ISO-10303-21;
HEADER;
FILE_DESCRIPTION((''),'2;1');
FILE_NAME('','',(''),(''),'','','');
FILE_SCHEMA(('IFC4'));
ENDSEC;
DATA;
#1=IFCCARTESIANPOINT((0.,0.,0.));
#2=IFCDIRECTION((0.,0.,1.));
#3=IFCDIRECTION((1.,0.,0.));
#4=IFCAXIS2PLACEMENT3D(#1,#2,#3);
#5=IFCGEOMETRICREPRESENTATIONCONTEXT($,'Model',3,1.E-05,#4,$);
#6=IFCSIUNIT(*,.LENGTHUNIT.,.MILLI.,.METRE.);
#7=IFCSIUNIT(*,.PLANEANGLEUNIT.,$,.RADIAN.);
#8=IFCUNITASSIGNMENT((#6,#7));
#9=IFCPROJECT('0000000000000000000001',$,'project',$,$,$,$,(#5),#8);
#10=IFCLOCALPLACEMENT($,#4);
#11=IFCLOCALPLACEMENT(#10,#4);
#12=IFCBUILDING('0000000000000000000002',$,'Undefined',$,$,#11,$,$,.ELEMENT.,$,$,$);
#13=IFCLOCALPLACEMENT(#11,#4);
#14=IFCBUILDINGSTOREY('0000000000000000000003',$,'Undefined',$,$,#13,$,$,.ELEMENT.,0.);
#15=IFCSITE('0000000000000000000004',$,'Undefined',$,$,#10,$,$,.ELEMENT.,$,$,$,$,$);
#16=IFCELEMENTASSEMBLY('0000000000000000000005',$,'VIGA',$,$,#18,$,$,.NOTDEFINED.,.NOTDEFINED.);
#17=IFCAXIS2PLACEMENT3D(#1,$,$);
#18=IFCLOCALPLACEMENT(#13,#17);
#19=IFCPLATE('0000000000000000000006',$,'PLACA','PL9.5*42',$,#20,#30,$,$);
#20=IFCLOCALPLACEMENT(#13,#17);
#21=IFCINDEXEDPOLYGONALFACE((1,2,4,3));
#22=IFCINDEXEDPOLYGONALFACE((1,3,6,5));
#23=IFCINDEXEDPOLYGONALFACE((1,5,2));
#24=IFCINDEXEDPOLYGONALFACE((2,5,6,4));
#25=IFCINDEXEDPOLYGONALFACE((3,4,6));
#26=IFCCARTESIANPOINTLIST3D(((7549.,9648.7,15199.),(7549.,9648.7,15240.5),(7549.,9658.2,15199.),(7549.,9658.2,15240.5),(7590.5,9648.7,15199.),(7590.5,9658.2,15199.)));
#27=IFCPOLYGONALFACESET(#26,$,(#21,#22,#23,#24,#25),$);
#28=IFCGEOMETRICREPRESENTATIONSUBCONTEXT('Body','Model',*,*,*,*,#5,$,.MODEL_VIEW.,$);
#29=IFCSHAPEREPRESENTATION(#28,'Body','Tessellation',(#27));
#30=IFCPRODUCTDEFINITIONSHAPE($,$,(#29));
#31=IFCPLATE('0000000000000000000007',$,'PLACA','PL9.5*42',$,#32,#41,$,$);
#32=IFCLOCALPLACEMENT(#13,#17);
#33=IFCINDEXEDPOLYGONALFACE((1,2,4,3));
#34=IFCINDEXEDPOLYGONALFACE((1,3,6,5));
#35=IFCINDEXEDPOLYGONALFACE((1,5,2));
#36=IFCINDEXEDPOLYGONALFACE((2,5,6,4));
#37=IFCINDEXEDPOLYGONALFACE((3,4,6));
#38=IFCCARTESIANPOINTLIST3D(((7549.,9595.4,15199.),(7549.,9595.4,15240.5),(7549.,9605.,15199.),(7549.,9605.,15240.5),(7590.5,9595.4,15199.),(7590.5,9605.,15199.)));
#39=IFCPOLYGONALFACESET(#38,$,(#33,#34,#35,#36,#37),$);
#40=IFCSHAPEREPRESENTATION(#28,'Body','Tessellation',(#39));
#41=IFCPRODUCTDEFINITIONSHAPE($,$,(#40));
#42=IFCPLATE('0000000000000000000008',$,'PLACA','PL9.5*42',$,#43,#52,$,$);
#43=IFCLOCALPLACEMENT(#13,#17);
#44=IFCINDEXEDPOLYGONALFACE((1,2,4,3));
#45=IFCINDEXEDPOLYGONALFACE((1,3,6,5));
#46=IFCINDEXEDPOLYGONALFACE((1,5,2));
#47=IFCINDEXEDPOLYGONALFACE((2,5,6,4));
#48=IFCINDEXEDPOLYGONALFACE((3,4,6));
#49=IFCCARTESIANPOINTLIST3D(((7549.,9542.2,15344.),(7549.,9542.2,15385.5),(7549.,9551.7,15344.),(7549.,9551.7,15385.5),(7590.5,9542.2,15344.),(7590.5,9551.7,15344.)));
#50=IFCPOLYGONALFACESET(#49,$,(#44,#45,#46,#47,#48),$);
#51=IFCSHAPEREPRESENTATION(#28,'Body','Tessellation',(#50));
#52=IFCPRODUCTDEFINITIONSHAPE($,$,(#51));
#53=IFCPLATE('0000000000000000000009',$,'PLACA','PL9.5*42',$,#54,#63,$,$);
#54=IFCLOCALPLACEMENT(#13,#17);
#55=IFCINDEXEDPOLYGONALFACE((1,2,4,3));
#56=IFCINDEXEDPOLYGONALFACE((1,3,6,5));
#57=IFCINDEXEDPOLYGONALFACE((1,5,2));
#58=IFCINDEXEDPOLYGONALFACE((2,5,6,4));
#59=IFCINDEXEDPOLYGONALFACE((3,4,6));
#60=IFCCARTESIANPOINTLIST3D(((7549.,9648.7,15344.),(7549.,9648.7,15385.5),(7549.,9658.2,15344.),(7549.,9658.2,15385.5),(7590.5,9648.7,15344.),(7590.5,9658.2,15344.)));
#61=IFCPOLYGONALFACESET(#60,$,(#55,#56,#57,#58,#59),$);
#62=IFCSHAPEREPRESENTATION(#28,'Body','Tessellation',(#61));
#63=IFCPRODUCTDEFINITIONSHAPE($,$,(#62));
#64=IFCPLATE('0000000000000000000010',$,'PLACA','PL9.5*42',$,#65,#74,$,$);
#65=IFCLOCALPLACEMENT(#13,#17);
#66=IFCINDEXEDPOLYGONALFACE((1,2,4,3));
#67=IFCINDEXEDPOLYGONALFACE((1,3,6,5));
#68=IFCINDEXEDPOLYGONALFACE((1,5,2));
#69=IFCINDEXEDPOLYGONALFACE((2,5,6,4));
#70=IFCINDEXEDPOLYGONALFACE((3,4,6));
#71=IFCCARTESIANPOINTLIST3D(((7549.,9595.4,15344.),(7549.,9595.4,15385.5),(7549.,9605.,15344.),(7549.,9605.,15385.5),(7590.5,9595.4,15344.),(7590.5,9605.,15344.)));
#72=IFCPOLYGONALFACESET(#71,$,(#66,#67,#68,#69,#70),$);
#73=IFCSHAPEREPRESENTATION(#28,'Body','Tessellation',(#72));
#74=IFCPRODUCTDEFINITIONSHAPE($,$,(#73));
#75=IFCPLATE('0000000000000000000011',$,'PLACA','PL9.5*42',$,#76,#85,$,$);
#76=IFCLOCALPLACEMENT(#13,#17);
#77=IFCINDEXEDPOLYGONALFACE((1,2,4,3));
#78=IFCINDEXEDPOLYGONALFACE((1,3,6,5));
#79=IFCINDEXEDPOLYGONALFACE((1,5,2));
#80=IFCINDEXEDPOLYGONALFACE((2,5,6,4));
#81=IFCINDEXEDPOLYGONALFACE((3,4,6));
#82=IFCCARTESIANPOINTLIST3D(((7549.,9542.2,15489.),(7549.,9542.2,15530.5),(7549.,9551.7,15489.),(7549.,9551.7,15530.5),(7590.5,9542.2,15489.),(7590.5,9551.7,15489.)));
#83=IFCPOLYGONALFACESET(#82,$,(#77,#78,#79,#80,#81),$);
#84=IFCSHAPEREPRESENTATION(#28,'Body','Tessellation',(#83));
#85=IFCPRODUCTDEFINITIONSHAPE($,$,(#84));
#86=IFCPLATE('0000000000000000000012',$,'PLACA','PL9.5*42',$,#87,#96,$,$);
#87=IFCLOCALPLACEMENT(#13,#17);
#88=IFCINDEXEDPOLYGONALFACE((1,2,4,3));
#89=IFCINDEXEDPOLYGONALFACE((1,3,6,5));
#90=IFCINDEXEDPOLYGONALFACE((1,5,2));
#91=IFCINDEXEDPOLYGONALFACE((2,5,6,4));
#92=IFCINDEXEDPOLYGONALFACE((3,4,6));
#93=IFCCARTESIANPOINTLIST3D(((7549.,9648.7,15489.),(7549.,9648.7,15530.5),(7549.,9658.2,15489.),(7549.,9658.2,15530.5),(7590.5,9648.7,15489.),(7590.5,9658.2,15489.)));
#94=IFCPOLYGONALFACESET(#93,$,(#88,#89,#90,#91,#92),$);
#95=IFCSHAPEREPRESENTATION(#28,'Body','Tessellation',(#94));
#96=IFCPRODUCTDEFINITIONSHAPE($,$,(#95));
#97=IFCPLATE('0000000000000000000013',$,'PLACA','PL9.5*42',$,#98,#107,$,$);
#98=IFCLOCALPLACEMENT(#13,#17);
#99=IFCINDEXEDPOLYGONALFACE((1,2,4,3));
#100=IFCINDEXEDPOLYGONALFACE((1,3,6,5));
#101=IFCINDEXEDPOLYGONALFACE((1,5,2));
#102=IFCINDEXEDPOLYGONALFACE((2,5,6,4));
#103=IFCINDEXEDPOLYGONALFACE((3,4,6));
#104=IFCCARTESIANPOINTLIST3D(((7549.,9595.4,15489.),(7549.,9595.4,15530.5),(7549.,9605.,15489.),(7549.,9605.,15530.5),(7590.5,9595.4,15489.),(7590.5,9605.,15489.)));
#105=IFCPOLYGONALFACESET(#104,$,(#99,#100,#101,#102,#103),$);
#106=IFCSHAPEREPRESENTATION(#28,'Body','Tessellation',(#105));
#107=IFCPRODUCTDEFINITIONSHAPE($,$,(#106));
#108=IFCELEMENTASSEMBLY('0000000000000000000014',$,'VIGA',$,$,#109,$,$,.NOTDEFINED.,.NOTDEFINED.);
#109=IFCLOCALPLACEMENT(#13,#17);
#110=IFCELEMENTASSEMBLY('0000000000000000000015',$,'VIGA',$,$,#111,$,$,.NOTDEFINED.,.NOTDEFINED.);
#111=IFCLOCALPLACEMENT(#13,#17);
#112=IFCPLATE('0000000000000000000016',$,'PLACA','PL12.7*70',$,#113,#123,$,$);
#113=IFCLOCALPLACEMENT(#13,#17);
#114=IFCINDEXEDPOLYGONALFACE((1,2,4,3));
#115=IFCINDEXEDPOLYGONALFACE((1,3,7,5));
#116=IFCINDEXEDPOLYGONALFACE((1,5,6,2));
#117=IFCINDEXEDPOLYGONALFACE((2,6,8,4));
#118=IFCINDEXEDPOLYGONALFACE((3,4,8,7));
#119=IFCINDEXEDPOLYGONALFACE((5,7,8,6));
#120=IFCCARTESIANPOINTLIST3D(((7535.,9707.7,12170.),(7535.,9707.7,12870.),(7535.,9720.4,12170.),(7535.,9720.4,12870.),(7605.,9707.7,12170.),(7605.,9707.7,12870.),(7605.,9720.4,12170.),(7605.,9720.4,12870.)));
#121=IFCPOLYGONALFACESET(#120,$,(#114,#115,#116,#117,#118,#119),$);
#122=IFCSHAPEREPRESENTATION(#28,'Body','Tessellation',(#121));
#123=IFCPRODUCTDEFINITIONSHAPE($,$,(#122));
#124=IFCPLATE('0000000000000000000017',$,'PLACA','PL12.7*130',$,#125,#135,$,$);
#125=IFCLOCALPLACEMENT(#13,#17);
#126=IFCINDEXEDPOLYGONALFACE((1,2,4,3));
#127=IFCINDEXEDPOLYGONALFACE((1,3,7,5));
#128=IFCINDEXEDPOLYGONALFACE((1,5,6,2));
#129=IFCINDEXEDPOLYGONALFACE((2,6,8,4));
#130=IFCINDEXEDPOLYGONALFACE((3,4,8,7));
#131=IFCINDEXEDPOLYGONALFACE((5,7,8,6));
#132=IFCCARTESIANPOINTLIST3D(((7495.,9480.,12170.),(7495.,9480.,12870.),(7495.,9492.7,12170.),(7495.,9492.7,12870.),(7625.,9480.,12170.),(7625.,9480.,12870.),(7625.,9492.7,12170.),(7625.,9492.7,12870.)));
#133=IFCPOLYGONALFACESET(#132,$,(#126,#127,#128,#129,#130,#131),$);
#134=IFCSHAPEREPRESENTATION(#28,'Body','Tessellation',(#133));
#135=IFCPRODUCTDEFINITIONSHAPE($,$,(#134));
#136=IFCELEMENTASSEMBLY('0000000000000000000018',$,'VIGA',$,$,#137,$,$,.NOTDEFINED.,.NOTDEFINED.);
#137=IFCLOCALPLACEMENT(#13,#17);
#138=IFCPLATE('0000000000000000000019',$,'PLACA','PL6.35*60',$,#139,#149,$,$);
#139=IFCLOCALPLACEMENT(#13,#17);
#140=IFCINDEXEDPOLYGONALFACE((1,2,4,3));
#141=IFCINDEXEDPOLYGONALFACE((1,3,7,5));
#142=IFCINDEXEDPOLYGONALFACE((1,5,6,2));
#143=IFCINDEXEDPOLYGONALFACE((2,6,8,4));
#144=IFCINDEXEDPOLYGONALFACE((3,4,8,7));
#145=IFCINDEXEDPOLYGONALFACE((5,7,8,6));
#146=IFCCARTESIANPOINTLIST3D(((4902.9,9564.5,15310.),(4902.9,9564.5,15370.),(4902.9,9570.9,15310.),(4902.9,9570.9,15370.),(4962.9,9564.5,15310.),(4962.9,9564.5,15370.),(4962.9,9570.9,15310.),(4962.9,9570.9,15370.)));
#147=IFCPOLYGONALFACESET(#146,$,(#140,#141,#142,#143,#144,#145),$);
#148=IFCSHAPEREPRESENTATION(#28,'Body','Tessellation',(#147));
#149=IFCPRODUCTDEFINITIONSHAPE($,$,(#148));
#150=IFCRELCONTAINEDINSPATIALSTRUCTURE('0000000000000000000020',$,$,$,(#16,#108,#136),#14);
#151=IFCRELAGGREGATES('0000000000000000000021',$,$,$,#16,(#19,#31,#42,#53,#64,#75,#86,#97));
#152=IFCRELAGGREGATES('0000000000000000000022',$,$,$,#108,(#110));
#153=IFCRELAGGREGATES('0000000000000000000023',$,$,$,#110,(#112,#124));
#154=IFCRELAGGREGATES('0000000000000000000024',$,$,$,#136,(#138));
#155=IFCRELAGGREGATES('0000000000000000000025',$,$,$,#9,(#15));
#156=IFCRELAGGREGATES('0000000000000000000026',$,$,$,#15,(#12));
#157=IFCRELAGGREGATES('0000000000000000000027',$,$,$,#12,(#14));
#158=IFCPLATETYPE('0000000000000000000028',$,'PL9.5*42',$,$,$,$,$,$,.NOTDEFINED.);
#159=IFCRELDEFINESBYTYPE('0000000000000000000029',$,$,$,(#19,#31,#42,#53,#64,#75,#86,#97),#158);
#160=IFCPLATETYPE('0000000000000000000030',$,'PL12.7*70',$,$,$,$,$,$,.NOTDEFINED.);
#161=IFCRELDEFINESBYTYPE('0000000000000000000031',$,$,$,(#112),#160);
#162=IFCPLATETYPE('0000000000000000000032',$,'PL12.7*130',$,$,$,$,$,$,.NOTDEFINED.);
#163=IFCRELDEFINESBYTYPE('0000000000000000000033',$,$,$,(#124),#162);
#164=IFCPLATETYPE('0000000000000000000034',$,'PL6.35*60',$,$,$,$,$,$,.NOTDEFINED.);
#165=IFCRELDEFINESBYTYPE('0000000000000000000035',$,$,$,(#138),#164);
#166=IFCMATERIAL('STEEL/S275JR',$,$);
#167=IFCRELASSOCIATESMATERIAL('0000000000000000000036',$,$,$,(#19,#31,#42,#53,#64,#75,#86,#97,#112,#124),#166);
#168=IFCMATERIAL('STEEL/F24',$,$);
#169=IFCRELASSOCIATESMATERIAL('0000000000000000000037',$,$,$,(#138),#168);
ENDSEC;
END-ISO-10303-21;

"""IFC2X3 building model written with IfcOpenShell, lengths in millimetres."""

from ifc_helpers import new_model, si_unit, frame, origin_with_axes, place, context, subcontext, project, spatial, polyline, outline, extrude, material, type_object, element, aggregate, save


model = new_model("IFC2X3")

# Units and contexts
model_context = context("Model", 3, precision=1e-05, world=origin_with_axes())
body_context = subcontext(model_context, "Body", "Model", "MODEL_VIEW")
ifc_project = project(units=[si_unit("LENGTHUNIT", "METRE", prefix="MILLI"), si_unit("PLANEANGLEUNIT", "RADIAN")], contexts=[model_context])

# Site, building, storey
site_placement = place(None, origin_with_axes())
site = spatial("IfcSite", under=ifc_project, at=site_placement, Name="Undefined", CompositionType="ELEMENT")
building_placement = place(site_placement, origin_with_axes())
building = spatial("IfcBuilding", under=site, at=building_placement, Name="Undefined", CompositionType="ELEMENT")
storey_placement = place(building_placement, origin_with_axes())
storey = spatial("IfcBuildingStorey", under=building, at=storey_placement, Name="Undefined", CompositionType="ELEMENT", Elevation=0.0)

# Element assembly
assembly_1_placement = place(storey_placement, origin_with_axes())
assembly_1 = element("IfcElementAssembly", 1, at=assembly_1_placement, inside=storey, Name="VIGA", AssemblyPlace="NOTDEFINED", PredefinedType="NOTDEFINED")
ifc_material_1 = material(Name="STEEL/S275JR")

# Plates
plate_type_1 = type_object("IfcPlateType", Name="PL9.5*42", PredefinedType="NOTDEFINED")
plate_1_placement = place(assembly_1_placement, frame((7549.0, 9653.5, 15199.0), z_axis=(0.0, 1.0, 0.0), x_axis=(0.0, 0.0, 1.0)))
plate_1 = element("IfcPlate", 2, at=plate_1_placement, type_object=plate_type_1, material=ifc_material_1, Name="PLACA", Description="PL9.5*42", context=body_context, shape_type="SweptSolid", body=[
    extrude(outline(polyline([(0.0, 0.0), (41.5, 0.0), (0.0, 41.5), (0.0, 0.0)])), frame((0.0, 0.0, -4.7), z_axis=(0.0, 0.0, 1.0), x_axis=(1.0, 0.0, 0.0)), (0.0, 0.0, 1.0), 9.5),
])
plate_2_placement = place(assembly_1_placement, frame((7549.0, 9600.2, 15199.0), z_axis=(0.0, 1.0, 0.0), x_axis=(0.0, 0.0, 1.0)))
plate_2 = element("IfcPlate", 3, at=plate_2_placement, type_object=plate_type_1, material=ifc_material_1, Name="PLACA", Description="PL9.5*42", context=body_context, shape_type="SweptSolid", body=[
    extrude(outline(polyline([(0.0, 0.0), (41.5, 0.0), (0.0, 41.5), (0.0, 0.0)])), frame((0.0, 0.0, -4.7), z_axis=(0.0, 0.0, 1.0), x_axis=(1.0, 0.0, 0.0)), (0.0, 0.0, 1.0), 9.5),
])
plate_3_placement = place(assembly_1_placement, frame((7549.0, 9547.0, 15344.0), z_axis=(0.0, 1.0, 0.0), x_axis=(0.0, 0.0, 1.0)))
plate_3 = element("IfcPlate", 4, at=plate_3_placement, type_object=plate_type_1, material=ifc_material_1, Name="PLACA", Description="PL9.5*42", context=body_context, shape_type="SweptSolid", body=[
    extrude(outline(polyline([(0.0, 0.0), (41.5, 0.0), (0.0, 41.5), (0.0, 0.0)])), frame((0.0, 0.0, -4.7), z_axis=(0.0, 0.0, 1.0), x_axis=(1.0, 0.0, 0.0)), (0.0, 0.0, 1.0), 9.5),
])
plate_4_placement = place(assembly_1_placement, frame((7549.0, 9653.5, 15344.0), z_axis=(0.0, 1.0, 0.0), x_axis=(0.0, 0.0, 1.0)))
plate_4 = element("IfcPlate", 5, at=plate_4_placement, type_object=plate_type_1, material=ifc_material_1, Name="PLACA", Description="PL9.5*42", context=body_context, shape_type="SweptSolid", body=[
    extrude(outline(polyline([(0.0, 0.0), (41.5, 0.0), (0.0, 41.5), (0.0, 0.0)])), frame((0.0, 0.0, -4.7), z_axis=(0.0, 0.0, 1.0), x_axis=(1.0, 0.0, 0.0)), (0.0, 0.0, 1.0), 9.5),
])
plate_5_placement = place(assembly_1_placement, frame((7549.0, 9600.2, 15344.0), z_axis=(0.0, 1.0, 0.0), x_axis=(0.0, 0.0, 1.0)))
plate_5 = element("IfcPlate", 6, at=plate_5_placement, type_object=plate_type_1, material=ifc_material_1, Name="PLACA", Description="PL9.5*42", context=body_context, shape_type="SweptSolid", body=[
    extrude(outline(polyline([(0.0, 0.0), (41.5, 0.0), (0.0, 41.5), (0.0, 0.0)])), frame((0.0, 0.0, -4.7), z_axis=(0.0, 0.0, 1.0), x_axis=(1.0, 0.0, 0.0)), (0.0, 0.0, 1.0), 9.5),
])
plate_6_placement = place(assembly_1_placement, frame((7549.0, 9547.0, 15489.0), z_axis=(0.0, 1.0, 0.0), x_axis=(0.0, 0.0, 1.0)))
plate_6 = element("IfcPlate", 7, at=plate_6_placement, type_object=plate_type_1, material=ifc_material_1, Name="PLACA", Description="PL9.5*42", context=body_context, shape_type="SweptSolid", body=[
    extrude(outline(polyline([(0.0, 0.0), (41.5, 0.0), (0.0, 41.5), (0.0, 0.0)])), frame((0.0, 0.0, -4.7), z_axis=(0.0, 0.0, 1.0), x_axis=(1.0, 0.0, 0.0)), (0.0, 0.0, 1.0), 9.5),
])
plate_7_placement = place(assembly_1_placement, frame((7549.0, 9653.5, 15489.0), z_axis=(0.0, 1.0, 0.0), x_axis=(0.0, 0.0, 1.0)))
plate_7 = element("IfcPlate", 8, at=plate_7_placement, type_object=plate_type_1, material=ifc_material_1, Name="PLACA", Description="PL9.5*42", context=body_context, shape_type="SweptSolid", body=[
    extrude(outline(polyline([(0.0, 0.0), (41.5, 0.0), (0.0, 41.5), (0.0, 0.0)])), frame((0.0, 0.0, -4.7), z_axis=(0.0, 0.0, 1.0), x_axis=(1.0, 0.0, 0.0)), (0.0, 0.0, 1.0), 9.5),
])
plate_8_placement = place(assembly_1_placement, frame((7549.0, 9600.2, 15489.0), z_axis=(0.0, 1.0, 0.0), x_axis=(0.0, 0.0, 1.0)))
plate_8 = element("IfcPlate", 9, at=plate_8_placement, type_object=plate_type_1, material=ifc_material_1, Name="PLACA", Description="PL9.5*42", context=body_context, shape_type="SweptSolid", body=[
    extrude(outline(polyline([(0.0, 0.0), (41.5, 0.0), (0.0, 41.5), (0.0, 0.0)])), frame((0.0, 0.0, -4.7), z_axis=(0.0, 0.0, 1.0), x_axis=(1.0, 0.0, 0.0)), (0.0, 0.0, 1.0), 9.5),
])
aggregate(assembly_1, [plate_1, plate_2, plate_3, plate_4, plate_5, plate_6, plate_7, plate_8])

# Element assemblies, plates
assembly_2_placement = place(storey_placement, origin_with_axes())
assembly_2 = element("IfcElementAssembly", 10, at=assembly_2_placement, inside=storey, Name="VIGA", AssemblyPlace="NOTDEFINED", PredefinedType="NOTDEFINED")
assembly_3_placement = place(assembly_2_placement, origin_with_axes())
assembly_3 = element("IfcElementAssembly", 11, at=assembly_3_placement, Name="VIGA", AssemblyPlace="NOTDEFINED", PredefinedType="NOTDEFINED")
aggregate(assembly_2, [assembly_3])
plate_type_2 = type_object("IfcPlateType", Name="PL12.7*70", PredefinedType="NOTDEFINED")
plate_9_placement = place(assembly_3_placement, frame((7535.0, 9714.0, 12870.0), z_axis=(0.0, 1.0, 0.0), x_axis=(1.0, 0.0, 0.0)))
plate_9 = element("IfcPlate", 12, at=plate_9_placement, type_object=plate_type_2, material=ifc_material_1, Name="PLACA", Description="PL12.7*70", context=body_context, shape_type="SweptSolid", body=[
    extrude(outline(polyline([(0.0, 0.0), (70.0, 0.0), (70.0, 700.0), (0.0, 700.0), (0.0, 0.0)])), frame((0.0, 0.0, -6.3), z_axis=(0.0, 0.0, 1.0), x_axis=(1.0, 0.0, 0.0)), (0.0, 0.0, 1.0), 12.7),
])
plate_type_3 = type_object("IfcPlateType", Name="PL12.7*130", PredefinedType="NOTDEFINED")
plate_10_placement = place(assembly_3_placement, frame((7495.0, 9486.3, 12870.0), z_axis=(0.0, 1.0, 0.0), x_axis=(1.0, 0.0, 0.0)))
plate_10 = element("IfcPlate", 13, at=plate_10_placement, type_object=plate_type_3, material=ifc_material_1, Name="PLACA", Description="PL12.7*130", context=body_context, shape_type="SweptSolid", body=[
    extrude(outline(polyline([(0.0, 0.0), (130.0, 0.0), (130.0, 700.0), (0.0, 700.0), (0.0, 0.0)])), frame((0.0, 0.0, -6.3), z_axis=(0.0, 0.0, 1.0), x_axis=(1.0, 0.0, 0.0)), (0.0, 0.0, 1.0), 12.7),
])
aggregate(assembly_3, [plate_9, plate_10])

# Element assembly, plate
assembly_4_placement = place(storey_placement, origin_with_axes())
assembly_4 = element("IfcElementAssembly", 14, at=assembly_4_placement, inside=storey, Name="VIGA", AssemblyPlace="NOTDEFINED", PredefinedType="NOTDEFINED")
ifc_material_2 = material(Name="STEEL/F24")
plate_type_4 = type_object("IfcPlateType", Name="PL6.35*60", PredefinedType="NOTDEFINED")
plate_11_placement = place(assembly_4_placement, frame((4902.9, 9567.7, 15370.0), z_axis=(0.0, 1.0, 0.0), x_axis=(1.0, 0.0, 0.0)))
plate_11 = element("IfcPlate", 15, at=plate_11_placement, type_object=plate_type_4, material=ifc_material_2, Name="PLACA", Description="PL6.35*60", context=body_context, shape_type="SweptSolid", body=[
    extrude(outline(polyline([(0.0, 0.0), (60.0, 0.0), (60.0, 60.0), (0.0, 60.0), (0.0, 0.0)])), frame((0.0, 0.0, -3.2), z_axis=(0.0, 0.0, 1.0), x_axis=(1.0, 0.0, 0.0)), (0.0, 0.0, 1.0), 6.4),
])

aggregate(assembly_4, [plate_11])

save(model, "model.ifc")
